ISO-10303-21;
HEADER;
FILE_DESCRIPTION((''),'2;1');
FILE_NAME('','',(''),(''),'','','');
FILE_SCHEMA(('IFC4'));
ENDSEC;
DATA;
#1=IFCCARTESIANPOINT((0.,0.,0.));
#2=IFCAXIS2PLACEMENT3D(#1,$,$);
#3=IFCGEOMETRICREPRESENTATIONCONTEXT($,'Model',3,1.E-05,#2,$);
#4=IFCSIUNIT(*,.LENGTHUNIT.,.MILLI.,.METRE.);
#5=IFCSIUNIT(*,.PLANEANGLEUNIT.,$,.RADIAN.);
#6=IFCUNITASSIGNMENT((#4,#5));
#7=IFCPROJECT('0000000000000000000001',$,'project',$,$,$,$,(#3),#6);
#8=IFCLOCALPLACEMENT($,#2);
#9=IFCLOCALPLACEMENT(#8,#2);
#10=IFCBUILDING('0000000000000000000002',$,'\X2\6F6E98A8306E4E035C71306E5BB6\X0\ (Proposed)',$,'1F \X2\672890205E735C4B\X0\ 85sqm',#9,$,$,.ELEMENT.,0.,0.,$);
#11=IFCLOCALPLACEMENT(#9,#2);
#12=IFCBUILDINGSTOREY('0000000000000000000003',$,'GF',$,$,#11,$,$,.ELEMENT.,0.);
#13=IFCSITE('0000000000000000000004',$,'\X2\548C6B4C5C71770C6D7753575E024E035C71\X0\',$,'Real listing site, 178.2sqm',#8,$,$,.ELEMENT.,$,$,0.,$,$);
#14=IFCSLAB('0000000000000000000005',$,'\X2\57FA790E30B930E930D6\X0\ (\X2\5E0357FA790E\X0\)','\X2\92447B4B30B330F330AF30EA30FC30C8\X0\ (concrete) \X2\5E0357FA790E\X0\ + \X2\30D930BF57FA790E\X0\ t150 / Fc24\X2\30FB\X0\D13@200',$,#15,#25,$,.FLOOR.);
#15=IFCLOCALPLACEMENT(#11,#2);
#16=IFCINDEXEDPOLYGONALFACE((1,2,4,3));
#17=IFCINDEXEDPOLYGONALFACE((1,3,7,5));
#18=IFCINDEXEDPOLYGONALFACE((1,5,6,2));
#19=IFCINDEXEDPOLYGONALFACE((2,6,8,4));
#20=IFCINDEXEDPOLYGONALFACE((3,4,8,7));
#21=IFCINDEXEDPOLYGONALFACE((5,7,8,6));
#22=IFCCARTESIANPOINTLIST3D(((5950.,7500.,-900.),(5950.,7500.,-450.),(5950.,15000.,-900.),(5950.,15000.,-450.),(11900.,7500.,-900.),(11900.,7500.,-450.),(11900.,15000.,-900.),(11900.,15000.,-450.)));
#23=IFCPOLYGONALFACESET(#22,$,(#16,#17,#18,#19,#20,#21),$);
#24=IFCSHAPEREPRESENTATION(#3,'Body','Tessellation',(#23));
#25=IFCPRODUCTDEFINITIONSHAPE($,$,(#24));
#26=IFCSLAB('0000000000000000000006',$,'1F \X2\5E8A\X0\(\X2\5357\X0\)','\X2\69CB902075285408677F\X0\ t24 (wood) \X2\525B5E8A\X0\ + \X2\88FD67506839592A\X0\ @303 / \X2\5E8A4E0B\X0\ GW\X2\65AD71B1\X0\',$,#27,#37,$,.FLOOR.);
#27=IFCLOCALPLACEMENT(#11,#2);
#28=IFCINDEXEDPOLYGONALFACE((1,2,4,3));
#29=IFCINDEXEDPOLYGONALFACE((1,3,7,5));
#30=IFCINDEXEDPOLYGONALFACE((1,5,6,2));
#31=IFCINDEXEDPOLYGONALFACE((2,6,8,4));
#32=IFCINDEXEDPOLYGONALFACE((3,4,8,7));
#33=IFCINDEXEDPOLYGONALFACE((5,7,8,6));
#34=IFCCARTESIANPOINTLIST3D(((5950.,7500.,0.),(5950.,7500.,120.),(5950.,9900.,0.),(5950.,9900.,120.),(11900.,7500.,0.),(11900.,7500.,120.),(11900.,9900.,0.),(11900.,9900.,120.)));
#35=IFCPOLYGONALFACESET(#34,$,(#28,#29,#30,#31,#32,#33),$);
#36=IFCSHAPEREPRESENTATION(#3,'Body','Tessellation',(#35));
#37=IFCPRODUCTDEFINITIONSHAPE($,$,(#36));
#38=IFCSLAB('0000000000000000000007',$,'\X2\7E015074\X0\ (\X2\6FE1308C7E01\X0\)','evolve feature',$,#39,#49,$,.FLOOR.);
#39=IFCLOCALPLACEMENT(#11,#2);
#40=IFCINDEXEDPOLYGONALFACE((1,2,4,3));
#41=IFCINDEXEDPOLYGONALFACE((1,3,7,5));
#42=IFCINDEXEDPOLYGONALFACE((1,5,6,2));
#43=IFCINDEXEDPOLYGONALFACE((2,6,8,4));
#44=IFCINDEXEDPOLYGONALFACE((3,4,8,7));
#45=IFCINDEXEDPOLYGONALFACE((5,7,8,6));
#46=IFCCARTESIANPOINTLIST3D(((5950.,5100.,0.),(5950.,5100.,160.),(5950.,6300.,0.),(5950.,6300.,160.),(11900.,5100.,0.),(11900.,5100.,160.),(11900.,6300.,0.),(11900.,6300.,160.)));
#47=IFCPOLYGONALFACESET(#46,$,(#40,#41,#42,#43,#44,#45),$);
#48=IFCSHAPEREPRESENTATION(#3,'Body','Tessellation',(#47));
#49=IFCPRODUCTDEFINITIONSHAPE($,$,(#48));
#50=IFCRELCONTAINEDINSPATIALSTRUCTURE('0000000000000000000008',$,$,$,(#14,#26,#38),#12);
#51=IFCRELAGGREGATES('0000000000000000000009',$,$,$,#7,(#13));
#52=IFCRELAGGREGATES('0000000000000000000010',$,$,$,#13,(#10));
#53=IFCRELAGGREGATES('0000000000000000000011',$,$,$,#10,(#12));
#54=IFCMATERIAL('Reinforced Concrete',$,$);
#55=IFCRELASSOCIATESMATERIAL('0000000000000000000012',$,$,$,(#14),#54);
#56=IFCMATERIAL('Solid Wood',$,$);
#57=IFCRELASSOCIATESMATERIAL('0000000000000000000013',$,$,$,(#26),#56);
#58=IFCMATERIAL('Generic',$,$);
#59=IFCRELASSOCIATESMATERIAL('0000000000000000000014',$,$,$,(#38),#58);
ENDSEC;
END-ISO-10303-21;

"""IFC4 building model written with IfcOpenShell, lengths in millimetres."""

from ifc_helpers import new_model, si_unit, frame, frame_2d, origin, place, context, project, spatial, rectangle, extrude, material, element, save


model = new_model("IFC4")

# Units and contexts
model_context = context("Model", 3, precision=1e-05, world=origin())
ifc_project = project(units=[si_unit("LENGTHUNIT", "METRE", prefix="MILLI"), si_unit("PLANEANGLEUNIT", "RADIAN")], contexts=[model_context])

# Site, building, storey
site_placement = place(None, origin())
site = spatial("IfcSite", under=ifc_project, at=site_placement, Name="和歌山県海南市七山", ObjectType="Real listing site, 178.2sqm", CompositionType="ELEMENT", RefElevation=0.0)
building_placement = place(site_placement, origin())
building = spatial("IfcBuilding", under=site, at=building_placement, Name="潮風の七山の家 (Proposed)", ObjectType="1F 木造平屋 85sqm", CompositionType="ELEMENT", ElevationOfRefHeight=0.0, ElevationOfTerrain=0.0)
storey_placement = place(building_placement, origin())
storey = spatial("IfcBuildingStorey", under=building, at=storey_placement, Name="GF", CompositionType="ELEMENT", Elevation=0.0)

# Slabs
ifc_material_1 = material(Name="Reinforced Concrete")
slab_1_placement = place(storey_placement, frame((2975.0, 3750.0, -450.0)))
element("IfcSlab", 1, at=slab_1_placement, inside=storey, material=ifc_material_1, Name="基礎スラブ (布基礎)", Description="鉄筋コンクリート (concrete) 布基礎 + ベタ基礎 t150 / Fc24・D13@200", PredefinedType="FLOOR", context=model_context, shape_type="SweptSolid", body=[
    extrude(rectangle(XDim=5950.0, YDim=7500.0, at=frame_2d((2975.0, 3750.0))), frame((2975.0, 3750.0, -450.0)), (0.0, 0.0, 1.0), 450.0),
])
ifc_material_2 = material(Name="Solid Wood")
slab_2_placement = place(storey_placement, frame((2975.0, 3750.0, 0.0)))
element("IfcSlab", 2, at=slab_2_placement, inside=storey, material=ifc_material_2, Name="1F 床(南)", Description="構造用合板 t24 (wood) 剛床 + 製材根太 @303 / 床下 GW断熱", PredefinedType="FLOOR", context=model_context, shape_type="SweptSolid", body=[
    extrude(rectangle(XDim=5950.0, YDim=2400.0, at=frame_2d((2975.0, 1200.0))), frame((2975.0, 3750.0, 0.0)), (0.0, 0.0, 1.0), 120.0),
])
ifc_material_3 = material(Name="Generic")
slab_3_placement = place(storey_placement, frame((2975.0, 2550.0, 0.0)))
element("IfcSlab", 3, at=slab_3_placement, inside=storey, material=ifc_material_3, Name="縁側 (濡れ縁)", Description="evolve feature", PredefinedType="FLOOR", context=model_context, shape_type="SweptSolid", body=[
    extrude(rectangle(XDim=5950.0, YDim=1200.0, at=frame_2d((2975.0, 600.0))), frame((2975.0, 2550.0, 0.0)), (0.0, 0.0, 1.0), 160.0),
])

save(model, "model.ifc")
